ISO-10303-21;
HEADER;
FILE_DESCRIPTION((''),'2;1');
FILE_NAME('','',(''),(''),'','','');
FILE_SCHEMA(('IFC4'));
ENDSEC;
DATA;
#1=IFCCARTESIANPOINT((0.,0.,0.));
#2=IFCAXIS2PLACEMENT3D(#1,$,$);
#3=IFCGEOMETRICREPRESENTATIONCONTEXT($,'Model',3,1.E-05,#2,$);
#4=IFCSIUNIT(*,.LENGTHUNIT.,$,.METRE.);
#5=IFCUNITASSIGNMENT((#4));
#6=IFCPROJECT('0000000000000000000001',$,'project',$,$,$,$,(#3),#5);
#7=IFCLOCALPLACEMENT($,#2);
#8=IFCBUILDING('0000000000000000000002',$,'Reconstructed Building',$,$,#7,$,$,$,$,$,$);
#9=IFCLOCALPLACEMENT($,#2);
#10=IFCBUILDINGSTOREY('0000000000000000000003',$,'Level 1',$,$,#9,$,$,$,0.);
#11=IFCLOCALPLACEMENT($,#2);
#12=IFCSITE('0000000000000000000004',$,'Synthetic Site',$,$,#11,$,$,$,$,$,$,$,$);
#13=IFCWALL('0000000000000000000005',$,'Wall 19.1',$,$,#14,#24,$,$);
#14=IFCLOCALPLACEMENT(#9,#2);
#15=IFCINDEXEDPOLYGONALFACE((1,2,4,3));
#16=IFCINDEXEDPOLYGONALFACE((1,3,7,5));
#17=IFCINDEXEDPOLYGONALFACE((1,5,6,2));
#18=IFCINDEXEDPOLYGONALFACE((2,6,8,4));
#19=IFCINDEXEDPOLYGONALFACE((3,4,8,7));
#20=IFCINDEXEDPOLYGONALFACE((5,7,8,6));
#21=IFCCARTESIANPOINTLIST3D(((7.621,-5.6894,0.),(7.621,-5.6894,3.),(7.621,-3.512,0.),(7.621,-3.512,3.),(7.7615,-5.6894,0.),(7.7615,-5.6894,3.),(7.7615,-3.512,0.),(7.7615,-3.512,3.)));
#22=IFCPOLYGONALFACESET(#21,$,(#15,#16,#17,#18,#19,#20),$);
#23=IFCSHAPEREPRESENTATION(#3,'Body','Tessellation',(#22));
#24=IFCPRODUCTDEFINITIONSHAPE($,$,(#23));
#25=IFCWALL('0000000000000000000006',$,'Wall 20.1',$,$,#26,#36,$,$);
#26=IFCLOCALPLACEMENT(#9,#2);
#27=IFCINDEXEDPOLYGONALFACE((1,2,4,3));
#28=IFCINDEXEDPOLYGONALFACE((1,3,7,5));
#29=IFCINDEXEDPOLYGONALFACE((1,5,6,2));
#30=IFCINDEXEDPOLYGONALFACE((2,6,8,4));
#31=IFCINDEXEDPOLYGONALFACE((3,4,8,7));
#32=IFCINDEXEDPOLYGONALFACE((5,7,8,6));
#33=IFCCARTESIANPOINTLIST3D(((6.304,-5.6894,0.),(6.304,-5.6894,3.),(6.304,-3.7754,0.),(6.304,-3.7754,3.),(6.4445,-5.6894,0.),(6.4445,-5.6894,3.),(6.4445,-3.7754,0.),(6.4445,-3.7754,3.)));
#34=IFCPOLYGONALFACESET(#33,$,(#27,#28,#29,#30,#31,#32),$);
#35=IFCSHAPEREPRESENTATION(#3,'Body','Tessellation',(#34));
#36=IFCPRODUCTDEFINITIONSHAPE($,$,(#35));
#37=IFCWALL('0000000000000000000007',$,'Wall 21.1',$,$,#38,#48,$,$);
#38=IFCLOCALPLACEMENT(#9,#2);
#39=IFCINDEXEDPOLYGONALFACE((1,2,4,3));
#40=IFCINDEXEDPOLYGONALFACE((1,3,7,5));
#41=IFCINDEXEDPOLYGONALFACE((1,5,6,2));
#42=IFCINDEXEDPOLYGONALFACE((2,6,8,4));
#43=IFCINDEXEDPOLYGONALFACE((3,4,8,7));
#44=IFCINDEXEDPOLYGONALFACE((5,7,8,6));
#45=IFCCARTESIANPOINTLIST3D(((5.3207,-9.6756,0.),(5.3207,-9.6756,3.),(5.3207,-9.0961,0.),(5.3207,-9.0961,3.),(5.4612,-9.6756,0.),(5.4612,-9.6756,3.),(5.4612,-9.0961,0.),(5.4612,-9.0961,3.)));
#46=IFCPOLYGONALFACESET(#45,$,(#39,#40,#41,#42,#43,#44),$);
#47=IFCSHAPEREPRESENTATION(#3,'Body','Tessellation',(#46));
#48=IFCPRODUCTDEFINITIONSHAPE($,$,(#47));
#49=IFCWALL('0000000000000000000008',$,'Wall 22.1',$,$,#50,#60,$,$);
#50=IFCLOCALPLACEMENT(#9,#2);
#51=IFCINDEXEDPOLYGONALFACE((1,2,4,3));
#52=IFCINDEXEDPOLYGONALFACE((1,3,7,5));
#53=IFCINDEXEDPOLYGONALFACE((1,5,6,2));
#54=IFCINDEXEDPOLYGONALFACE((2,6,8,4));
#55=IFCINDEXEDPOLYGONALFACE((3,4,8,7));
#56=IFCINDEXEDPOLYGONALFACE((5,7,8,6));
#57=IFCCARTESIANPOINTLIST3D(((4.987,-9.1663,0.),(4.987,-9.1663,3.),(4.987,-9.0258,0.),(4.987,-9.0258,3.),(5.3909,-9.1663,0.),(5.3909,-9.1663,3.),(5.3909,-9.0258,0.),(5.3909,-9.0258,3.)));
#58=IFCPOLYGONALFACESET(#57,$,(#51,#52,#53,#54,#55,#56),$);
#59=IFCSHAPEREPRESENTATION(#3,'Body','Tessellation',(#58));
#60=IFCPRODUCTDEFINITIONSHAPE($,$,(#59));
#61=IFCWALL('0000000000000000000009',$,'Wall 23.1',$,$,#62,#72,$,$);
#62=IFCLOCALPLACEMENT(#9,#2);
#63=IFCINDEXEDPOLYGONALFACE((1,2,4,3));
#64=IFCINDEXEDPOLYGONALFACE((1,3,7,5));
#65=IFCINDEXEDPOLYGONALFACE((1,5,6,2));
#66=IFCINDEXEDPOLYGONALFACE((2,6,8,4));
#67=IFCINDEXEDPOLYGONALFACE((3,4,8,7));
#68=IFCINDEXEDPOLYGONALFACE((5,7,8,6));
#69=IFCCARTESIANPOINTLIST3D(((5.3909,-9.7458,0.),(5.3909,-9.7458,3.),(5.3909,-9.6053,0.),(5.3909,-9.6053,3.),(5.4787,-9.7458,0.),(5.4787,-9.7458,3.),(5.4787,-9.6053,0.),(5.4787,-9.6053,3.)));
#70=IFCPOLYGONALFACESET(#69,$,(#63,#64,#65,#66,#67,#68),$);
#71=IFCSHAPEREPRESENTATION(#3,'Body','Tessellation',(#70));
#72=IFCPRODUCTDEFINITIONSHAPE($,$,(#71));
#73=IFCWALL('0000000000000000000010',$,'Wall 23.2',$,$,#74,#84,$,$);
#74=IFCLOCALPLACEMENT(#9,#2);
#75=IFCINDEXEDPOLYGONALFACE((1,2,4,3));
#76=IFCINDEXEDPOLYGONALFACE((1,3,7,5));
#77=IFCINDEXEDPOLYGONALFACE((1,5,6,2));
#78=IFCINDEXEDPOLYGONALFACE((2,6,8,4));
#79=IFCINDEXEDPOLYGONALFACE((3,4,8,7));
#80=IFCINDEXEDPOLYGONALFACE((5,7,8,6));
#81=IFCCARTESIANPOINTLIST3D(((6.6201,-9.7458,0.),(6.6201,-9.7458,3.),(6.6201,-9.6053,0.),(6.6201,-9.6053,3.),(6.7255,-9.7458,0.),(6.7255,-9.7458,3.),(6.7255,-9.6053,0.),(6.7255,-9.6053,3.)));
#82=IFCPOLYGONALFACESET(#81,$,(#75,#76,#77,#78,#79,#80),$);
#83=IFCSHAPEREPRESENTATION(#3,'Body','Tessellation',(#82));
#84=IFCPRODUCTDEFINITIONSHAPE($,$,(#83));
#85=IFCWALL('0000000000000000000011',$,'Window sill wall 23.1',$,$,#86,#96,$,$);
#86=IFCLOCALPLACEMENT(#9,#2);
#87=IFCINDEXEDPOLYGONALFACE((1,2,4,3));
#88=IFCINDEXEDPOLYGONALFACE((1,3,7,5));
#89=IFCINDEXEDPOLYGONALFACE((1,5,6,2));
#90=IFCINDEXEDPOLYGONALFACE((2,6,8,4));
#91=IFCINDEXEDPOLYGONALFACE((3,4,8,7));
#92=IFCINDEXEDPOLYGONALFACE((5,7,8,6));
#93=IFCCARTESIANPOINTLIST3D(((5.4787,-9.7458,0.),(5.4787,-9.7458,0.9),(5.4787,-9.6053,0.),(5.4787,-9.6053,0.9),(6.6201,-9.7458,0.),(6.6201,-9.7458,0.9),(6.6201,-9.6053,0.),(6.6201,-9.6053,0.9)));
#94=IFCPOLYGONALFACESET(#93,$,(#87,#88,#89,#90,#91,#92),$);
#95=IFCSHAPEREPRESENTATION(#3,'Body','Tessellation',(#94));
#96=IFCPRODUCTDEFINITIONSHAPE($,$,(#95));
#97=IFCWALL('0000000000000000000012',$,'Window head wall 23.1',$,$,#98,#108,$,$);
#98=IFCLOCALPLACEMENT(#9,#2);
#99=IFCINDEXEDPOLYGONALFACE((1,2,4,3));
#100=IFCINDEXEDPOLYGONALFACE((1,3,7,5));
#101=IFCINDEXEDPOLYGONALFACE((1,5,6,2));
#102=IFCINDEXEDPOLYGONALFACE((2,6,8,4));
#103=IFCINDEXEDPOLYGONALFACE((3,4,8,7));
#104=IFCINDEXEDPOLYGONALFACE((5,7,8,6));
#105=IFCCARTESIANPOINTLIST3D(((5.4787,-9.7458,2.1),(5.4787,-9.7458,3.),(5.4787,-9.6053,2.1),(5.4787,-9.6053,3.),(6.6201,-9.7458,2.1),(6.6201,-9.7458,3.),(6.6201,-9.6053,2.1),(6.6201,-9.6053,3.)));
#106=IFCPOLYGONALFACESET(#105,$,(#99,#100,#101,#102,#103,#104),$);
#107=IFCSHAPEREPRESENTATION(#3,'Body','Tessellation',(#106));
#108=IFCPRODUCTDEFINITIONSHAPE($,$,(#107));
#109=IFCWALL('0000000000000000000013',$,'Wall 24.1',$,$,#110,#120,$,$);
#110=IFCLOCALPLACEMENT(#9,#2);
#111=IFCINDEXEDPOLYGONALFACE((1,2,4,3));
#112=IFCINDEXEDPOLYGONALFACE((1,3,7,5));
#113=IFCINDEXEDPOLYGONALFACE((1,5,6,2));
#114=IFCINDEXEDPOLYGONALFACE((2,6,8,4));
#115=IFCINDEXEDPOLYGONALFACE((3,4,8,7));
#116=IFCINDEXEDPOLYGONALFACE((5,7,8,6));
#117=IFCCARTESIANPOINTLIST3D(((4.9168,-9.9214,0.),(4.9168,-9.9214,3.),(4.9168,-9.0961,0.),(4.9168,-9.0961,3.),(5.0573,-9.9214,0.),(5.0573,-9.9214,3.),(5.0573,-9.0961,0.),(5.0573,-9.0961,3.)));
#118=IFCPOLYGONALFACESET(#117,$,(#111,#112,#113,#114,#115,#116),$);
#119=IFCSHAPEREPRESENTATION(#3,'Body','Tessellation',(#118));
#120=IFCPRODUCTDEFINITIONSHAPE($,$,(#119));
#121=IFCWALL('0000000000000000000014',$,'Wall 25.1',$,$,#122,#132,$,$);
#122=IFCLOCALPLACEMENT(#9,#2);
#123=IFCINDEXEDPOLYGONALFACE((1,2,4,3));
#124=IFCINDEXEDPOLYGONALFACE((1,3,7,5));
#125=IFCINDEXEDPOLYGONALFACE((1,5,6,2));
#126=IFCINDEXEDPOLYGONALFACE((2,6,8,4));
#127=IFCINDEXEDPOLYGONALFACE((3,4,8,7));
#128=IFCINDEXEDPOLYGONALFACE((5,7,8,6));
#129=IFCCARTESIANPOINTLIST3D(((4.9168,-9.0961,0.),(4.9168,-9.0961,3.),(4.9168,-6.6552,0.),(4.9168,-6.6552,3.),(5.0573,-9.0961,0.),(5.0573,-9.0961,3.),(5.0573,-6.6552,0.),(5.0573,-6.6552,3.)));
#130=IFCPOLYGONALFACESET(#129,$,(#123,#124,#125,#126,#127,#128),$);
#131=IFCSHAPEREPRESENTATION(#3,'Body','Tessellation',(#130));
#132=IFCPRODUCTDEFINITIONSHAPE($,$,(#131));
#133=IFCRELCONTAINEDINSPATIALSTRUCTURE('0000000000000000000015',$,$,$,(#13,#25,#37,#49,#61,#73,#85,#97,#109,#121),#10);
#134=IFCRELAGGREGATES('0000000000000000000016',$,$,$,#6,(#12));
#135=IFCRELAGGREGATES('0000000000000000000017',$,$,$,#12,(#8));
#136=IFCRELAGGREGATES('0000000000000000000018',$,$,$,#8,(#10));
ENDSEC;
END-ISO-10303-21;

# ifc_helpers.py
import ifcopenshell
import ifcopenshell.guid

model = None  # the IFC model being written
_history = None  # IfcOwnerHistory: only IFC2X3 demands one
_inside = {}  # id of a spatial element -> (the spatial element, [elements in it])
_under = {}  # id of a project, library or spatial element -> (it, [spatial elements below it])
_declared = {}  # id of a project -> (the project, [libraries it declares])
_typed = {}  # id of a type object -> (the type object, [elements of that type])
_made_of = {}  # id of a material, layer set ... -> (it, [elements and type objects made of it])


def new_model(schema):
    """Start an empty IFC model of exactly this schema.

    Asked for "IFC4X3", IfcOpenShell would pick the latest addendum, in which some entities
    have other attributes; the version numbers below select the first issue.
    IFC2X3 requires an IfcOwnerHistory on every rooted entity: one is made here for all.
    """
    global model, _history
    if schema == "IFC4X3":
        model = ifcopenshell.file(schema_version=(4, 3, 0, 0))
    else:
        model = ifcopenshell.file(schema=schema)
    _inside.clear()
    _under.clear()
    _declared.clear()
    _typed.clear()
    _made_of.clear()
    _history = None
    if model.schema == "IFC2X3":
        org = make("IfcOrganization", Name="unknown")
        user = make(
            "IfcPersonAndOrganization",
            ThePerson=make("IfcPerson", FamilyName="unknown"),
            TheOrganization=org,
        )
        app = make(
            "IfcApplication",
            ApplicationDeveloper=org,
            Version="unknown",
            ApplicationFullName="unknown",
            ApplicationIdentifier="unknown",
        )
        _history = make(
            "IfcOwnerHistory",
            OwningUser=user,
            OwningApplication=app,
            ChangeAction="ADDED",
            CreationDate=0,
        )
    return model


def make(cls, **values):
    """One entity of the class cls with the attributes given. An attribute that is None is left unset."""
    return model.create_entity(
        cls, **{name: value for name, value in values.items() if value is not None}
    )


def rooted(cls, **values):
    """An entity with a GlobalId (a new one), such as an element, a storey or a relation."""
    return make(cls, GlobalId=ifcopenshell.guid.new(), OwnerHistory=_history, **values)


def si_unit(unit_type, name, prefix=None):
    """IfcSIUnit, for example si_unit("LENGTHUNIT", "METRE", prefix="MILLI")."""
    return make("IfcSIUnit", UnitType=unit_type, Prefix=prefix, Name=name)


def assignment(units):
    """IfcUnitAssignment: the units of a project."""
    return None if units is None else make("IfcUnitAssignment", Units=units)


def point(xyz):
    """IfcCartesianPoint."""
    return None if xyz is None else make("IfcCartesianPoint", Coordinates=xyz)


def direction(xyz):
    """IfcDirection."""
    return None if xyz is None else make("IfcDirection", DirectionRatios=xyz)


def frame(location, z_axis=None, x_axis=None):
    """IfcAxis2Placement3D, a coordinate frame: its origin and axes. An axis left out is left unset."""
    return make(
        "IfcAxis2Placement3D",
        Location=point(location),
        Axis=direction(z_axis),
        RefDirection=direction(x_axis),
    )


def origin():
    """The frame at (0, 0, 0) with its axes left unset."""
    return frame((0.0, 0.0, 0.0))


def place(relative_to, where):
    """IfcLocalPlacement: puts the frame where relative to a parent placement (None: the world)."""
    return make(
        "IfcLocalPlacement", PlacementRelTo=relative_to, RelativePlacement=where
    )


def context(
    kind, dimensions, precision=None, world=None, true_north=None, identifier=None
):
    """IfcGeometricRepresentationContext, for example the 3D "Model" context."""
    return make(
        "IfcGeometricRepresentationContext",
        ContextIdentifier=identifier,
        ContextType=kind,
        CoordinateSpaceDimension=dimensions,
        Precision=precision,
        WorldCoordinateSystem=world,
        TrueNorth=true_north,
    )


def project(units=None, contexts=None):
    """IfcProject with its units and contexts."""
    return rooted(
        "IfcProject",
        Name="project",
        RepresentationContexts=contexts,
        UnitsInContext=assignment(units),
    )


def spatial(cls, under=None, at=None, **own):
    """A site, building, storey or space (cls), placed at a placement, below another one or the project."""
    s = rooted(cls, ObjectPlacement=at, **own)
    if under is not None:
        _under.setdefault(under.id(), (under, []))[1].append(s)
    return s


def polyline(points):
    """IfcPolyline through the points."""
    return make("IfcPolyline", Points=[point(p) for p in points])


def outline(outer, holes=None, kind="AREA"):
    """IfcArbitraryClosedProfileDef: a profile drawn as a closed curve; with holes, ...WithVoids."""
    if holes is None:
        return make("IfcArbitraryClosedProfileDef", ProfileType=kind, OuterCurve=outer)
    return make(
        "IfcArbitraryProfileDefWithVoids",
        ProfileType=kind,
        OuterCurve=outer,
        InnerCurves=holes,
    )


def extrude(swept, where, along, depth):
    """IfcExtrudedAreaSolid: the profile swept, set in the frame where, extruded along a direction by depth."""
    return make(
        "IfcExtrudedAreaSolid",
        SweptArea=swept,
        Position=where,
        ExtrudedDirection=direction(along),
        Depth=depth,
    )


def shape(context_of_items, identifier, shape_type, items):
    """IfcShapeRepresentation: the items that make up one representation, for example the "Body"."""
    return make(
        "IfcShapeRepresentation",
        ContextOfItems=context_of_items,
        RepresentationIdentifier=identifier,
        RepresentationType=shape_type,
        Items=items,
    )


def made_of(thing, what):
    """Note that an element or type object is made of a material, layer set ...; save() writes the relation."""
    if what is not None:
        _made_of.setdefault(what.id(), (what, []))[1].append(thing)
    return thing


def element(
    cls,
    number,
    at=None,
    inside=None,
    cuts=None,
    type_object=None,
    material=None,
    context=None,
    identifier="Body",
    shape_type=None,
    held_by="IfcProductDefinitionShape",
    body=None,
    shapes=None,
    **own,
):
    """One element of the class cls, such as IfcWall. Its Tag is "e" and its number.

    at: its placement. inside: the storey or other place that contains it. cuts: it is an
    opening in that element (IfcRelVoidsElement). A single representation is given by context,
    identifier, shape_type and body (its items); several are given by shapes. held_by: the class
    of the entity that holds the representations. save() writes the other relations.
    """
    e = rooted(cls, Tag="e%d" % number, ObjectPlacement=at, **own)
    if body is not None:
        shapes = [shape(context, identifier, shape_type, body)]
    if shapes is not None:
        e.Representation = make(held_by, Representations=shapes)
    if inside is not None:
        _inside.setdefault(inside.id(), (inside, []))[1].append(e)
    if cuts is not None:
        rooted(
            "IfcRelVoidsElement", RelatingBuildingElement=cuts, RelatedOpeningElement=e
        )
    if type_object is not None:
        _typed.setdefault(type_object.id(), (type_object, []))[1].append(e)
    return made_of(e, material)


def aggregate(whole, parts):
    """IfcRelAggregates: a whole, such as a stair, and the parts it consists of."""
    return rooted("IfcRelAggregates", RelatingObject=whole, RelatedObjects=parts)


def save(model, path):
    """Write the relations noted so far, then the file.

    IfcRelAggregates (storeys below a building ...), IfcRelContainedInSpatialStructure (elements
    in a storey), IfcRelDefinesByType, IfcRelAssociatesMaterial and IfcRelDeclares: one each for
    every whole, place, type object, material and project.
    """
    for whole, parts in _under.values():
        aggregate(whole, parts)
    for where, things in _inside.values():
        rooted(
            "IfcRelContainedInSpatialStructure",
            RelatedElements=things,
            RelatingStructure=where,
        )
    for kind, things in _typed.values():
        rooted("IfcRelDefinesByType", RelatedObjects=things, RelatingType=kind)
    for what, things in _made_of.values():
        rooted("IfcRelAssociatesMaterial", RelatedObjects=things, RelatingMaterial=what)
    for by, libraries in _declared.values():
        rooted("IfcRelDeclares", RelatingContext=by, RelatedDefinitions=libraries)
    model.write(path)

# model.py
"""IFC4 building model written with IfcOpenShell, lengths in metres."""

from ifc_helpers import new_model, si_unit, frame, origin, place, context, project, spatial, polyline, outline, extrude, element, save


model = new_model("IFC4")

# Units and contexts
model_context = context("Model", 3, precision=1e-05, world=origin())
ifc_project = project(units=[si_unit("LENGTHUNIT", "METRE")], contexts=[model_context])

# Site, building, storey
site_placement = place(None, origin())
site = spatial("IfcSite", under=ifc_project, at=site_placement, Name="Synthetic Site")
building_placement = place(None, origin())
building = spatial("IfcBuilding", under=site, at=building_placement, Name="Reconstructed Building")
storey_placement = place(None, origin())
storey = spatial("IfcBuildingStorey", under=building, at=storey_placement, Name="Level 1", Elevation=0.0)

# Walls
wall_1_placement = place(None, origin())
element("IfcWall", 1, at=wall_1_placement, inside=storey, Name="Wall 19.1", context=model_context, shape_type="SweptSolid", body=[
    extrude(outline(polyline([(7.621, -3.512), (7.621, -5.6894), (7.7615, -5.6894), (7.7615, -3.512), (7.621, -3.512)])), frame((0.0, 0.0, 0.0), z_axis=(0.0, 0.0, 1.0)), (0.0, 0.0, 1.0), 3.0),
])
wall_2_placement = place(None, origin())
element("IfcWall", 2, at=wall_2_placement, inside=storey, Name="Wall 20.1", context=model_context, shape_type="SweptSolid", body=[
    extrude(outline(polyline([(6.304, -3.7754), (6.304, -5.6894), (6.4445, -5.6894), (6.4445, -3.7754), (6.304, -3.7754)])), frame((0.0, 0.0, 0.0), z_axis=(0.0, 0.0, 1.0)), (0.0, 0.0, 1.0), 3.0),
])
wall_3_placement = place(None, origin())
element("IfcWall", 3, at=wall_3_placement, inside=storey, Name="Wall 21.1", context=model_context, shape_type="SweptSolid", body=[
    extrude(outline(polyline([(5.3207, -9.0961), (5.3207, -9.6756), (5.4612, -9.6756), (5.4612, -9.0961), (5.3207, -9.0961)])), frame((0.0, 0.0, 0.0), z_axis=(0.0, 0.0, 1.0)), (0.0, 0.0, 1.0), 3.0),
])
wall_4_placement = place(None, origin())
element("IfcWall", 4, at=wall_4_placement, inside=storey, Name="Wall 22.1", context=model_context, shape_type="SweptSolid", body=[
    extrude(outline(polyline([(5.3909, -9.0258), (4.987, -9.0258), (4.987, -9.1663), (5.3909, -9.1663), (5.3909, -9.0258)])), frame((0.0, 0.0, 0.0), z_axis=(0.0, 0.0, 1.0)), (0.0, 0.0, 1.0), 3.0),
])
wall_5_placement = place(None, origin())
element("IfcWall", 5, at=wall_5_placement, inside=storey, Name="Wall 23.1", context=model_context, shape_type="SweptSolid", body=[
    extrude(outline(polyline([(5.3909, -9.7458), (5.4787, -9.7458), (5.4787, -9.6053), (5.3909, -9.6053), (5.3909, -9.7458)])), frame((0.0, 0.0, 0.0), z_axis=(0.0, 0.0, 1.0)), (0.0, 0.0, 1.0), 3.0),
])
wall_6_placement = place(None, origin())
element("IfcWall", 6, at=wall_6_placement, inside=storey, Name="Wall 23.2", context=model_context, shape_type="SweptSolid", body=[
    extrude(outline(polyline([(6.6201, -9.7458), (6.7255, -9.7458), (6.7255, -9.6053), (6.6201, -9.6053), (6.6201, -9.7458)])), frame((0.0, 0.0, 0.0), z_axis=(0.0, 0.0, 1.0)), (0.0, 0.0, 1.0), 3.0),
])
wall_7_placement = place(None, origin())
element("IfcWall", 7, at=wall_7_placement, inside=storey, Name="Window sill wall 23.1", context=model_context, shape_type="SweptSolid", body=[
    extrude(outline(polyline([(5.4787, -9.7458), (6.6201, -9.7458), (6.6201, -9.6053), (5.4787, -9.6053), (5.4787, -9.7458)])), frame((0.0, 0.0, 0.0), z_axis=(0.0, 0.0, 1.0)), (0.0, 0.0, 1.0), 0.9),
])
wall_8_placement = place(None, origin())
element("IfcWall", 8, at=wall_8_placement, inside=storey, Name="Window head wall 23.1", context=model_context, shape_type="SweptSolid", body=[
    extrude(outline(polyline([(5.4787, -9.7458), (6.6201, -9.7458), (6.6201, -9.6053), (5.4787, -9.6053), (5.4787, -9.7458)])), frame((0.0, 0.0, 2.1), z_axis=(0.0, 0.0, 1.0)), (0.0, 0.0, 1.0), 0.9),
])
wall_9_placement = place(None, origin())
element("IfcWall", 9, at=wall_9_placement, inside=storey, Name="Wall 24.1", context=model_context, shape_type="SweptSolid", body=[
    extrude(outline(polyline([(4.9168, -9.0961), (4.9168, -9.9214), (5.0573, -9.9214), (5.0573, -9.0961), (4.9168, -9.0961)])), frame((0.0, 0.0, 0.0), z_axis=(0.0, 0.0, 1.0)), (0.0, 0.0, 1.0), 3.0),
])
wall_10_placement = place(None, origin())
element("IfcWall", 10, at=wall_10_placement, inside=storey, Name="Wall 25.1", context=model_context, shape_type="SweptSolid", body=[
    extrude(outline(polyline([(5.0573, -9.0961), (5.0573, -6.6552), (4.9168, -6.6552), (4.9168, -9.0961), (5.0573, -9.0961)])), frame((0.0, 0.0, 0.0), z_axis=(0.0, 0.0, 1.0)), (0.0, 0.0, 1.0), 3.0),
])

save(model, "model.ifc")
